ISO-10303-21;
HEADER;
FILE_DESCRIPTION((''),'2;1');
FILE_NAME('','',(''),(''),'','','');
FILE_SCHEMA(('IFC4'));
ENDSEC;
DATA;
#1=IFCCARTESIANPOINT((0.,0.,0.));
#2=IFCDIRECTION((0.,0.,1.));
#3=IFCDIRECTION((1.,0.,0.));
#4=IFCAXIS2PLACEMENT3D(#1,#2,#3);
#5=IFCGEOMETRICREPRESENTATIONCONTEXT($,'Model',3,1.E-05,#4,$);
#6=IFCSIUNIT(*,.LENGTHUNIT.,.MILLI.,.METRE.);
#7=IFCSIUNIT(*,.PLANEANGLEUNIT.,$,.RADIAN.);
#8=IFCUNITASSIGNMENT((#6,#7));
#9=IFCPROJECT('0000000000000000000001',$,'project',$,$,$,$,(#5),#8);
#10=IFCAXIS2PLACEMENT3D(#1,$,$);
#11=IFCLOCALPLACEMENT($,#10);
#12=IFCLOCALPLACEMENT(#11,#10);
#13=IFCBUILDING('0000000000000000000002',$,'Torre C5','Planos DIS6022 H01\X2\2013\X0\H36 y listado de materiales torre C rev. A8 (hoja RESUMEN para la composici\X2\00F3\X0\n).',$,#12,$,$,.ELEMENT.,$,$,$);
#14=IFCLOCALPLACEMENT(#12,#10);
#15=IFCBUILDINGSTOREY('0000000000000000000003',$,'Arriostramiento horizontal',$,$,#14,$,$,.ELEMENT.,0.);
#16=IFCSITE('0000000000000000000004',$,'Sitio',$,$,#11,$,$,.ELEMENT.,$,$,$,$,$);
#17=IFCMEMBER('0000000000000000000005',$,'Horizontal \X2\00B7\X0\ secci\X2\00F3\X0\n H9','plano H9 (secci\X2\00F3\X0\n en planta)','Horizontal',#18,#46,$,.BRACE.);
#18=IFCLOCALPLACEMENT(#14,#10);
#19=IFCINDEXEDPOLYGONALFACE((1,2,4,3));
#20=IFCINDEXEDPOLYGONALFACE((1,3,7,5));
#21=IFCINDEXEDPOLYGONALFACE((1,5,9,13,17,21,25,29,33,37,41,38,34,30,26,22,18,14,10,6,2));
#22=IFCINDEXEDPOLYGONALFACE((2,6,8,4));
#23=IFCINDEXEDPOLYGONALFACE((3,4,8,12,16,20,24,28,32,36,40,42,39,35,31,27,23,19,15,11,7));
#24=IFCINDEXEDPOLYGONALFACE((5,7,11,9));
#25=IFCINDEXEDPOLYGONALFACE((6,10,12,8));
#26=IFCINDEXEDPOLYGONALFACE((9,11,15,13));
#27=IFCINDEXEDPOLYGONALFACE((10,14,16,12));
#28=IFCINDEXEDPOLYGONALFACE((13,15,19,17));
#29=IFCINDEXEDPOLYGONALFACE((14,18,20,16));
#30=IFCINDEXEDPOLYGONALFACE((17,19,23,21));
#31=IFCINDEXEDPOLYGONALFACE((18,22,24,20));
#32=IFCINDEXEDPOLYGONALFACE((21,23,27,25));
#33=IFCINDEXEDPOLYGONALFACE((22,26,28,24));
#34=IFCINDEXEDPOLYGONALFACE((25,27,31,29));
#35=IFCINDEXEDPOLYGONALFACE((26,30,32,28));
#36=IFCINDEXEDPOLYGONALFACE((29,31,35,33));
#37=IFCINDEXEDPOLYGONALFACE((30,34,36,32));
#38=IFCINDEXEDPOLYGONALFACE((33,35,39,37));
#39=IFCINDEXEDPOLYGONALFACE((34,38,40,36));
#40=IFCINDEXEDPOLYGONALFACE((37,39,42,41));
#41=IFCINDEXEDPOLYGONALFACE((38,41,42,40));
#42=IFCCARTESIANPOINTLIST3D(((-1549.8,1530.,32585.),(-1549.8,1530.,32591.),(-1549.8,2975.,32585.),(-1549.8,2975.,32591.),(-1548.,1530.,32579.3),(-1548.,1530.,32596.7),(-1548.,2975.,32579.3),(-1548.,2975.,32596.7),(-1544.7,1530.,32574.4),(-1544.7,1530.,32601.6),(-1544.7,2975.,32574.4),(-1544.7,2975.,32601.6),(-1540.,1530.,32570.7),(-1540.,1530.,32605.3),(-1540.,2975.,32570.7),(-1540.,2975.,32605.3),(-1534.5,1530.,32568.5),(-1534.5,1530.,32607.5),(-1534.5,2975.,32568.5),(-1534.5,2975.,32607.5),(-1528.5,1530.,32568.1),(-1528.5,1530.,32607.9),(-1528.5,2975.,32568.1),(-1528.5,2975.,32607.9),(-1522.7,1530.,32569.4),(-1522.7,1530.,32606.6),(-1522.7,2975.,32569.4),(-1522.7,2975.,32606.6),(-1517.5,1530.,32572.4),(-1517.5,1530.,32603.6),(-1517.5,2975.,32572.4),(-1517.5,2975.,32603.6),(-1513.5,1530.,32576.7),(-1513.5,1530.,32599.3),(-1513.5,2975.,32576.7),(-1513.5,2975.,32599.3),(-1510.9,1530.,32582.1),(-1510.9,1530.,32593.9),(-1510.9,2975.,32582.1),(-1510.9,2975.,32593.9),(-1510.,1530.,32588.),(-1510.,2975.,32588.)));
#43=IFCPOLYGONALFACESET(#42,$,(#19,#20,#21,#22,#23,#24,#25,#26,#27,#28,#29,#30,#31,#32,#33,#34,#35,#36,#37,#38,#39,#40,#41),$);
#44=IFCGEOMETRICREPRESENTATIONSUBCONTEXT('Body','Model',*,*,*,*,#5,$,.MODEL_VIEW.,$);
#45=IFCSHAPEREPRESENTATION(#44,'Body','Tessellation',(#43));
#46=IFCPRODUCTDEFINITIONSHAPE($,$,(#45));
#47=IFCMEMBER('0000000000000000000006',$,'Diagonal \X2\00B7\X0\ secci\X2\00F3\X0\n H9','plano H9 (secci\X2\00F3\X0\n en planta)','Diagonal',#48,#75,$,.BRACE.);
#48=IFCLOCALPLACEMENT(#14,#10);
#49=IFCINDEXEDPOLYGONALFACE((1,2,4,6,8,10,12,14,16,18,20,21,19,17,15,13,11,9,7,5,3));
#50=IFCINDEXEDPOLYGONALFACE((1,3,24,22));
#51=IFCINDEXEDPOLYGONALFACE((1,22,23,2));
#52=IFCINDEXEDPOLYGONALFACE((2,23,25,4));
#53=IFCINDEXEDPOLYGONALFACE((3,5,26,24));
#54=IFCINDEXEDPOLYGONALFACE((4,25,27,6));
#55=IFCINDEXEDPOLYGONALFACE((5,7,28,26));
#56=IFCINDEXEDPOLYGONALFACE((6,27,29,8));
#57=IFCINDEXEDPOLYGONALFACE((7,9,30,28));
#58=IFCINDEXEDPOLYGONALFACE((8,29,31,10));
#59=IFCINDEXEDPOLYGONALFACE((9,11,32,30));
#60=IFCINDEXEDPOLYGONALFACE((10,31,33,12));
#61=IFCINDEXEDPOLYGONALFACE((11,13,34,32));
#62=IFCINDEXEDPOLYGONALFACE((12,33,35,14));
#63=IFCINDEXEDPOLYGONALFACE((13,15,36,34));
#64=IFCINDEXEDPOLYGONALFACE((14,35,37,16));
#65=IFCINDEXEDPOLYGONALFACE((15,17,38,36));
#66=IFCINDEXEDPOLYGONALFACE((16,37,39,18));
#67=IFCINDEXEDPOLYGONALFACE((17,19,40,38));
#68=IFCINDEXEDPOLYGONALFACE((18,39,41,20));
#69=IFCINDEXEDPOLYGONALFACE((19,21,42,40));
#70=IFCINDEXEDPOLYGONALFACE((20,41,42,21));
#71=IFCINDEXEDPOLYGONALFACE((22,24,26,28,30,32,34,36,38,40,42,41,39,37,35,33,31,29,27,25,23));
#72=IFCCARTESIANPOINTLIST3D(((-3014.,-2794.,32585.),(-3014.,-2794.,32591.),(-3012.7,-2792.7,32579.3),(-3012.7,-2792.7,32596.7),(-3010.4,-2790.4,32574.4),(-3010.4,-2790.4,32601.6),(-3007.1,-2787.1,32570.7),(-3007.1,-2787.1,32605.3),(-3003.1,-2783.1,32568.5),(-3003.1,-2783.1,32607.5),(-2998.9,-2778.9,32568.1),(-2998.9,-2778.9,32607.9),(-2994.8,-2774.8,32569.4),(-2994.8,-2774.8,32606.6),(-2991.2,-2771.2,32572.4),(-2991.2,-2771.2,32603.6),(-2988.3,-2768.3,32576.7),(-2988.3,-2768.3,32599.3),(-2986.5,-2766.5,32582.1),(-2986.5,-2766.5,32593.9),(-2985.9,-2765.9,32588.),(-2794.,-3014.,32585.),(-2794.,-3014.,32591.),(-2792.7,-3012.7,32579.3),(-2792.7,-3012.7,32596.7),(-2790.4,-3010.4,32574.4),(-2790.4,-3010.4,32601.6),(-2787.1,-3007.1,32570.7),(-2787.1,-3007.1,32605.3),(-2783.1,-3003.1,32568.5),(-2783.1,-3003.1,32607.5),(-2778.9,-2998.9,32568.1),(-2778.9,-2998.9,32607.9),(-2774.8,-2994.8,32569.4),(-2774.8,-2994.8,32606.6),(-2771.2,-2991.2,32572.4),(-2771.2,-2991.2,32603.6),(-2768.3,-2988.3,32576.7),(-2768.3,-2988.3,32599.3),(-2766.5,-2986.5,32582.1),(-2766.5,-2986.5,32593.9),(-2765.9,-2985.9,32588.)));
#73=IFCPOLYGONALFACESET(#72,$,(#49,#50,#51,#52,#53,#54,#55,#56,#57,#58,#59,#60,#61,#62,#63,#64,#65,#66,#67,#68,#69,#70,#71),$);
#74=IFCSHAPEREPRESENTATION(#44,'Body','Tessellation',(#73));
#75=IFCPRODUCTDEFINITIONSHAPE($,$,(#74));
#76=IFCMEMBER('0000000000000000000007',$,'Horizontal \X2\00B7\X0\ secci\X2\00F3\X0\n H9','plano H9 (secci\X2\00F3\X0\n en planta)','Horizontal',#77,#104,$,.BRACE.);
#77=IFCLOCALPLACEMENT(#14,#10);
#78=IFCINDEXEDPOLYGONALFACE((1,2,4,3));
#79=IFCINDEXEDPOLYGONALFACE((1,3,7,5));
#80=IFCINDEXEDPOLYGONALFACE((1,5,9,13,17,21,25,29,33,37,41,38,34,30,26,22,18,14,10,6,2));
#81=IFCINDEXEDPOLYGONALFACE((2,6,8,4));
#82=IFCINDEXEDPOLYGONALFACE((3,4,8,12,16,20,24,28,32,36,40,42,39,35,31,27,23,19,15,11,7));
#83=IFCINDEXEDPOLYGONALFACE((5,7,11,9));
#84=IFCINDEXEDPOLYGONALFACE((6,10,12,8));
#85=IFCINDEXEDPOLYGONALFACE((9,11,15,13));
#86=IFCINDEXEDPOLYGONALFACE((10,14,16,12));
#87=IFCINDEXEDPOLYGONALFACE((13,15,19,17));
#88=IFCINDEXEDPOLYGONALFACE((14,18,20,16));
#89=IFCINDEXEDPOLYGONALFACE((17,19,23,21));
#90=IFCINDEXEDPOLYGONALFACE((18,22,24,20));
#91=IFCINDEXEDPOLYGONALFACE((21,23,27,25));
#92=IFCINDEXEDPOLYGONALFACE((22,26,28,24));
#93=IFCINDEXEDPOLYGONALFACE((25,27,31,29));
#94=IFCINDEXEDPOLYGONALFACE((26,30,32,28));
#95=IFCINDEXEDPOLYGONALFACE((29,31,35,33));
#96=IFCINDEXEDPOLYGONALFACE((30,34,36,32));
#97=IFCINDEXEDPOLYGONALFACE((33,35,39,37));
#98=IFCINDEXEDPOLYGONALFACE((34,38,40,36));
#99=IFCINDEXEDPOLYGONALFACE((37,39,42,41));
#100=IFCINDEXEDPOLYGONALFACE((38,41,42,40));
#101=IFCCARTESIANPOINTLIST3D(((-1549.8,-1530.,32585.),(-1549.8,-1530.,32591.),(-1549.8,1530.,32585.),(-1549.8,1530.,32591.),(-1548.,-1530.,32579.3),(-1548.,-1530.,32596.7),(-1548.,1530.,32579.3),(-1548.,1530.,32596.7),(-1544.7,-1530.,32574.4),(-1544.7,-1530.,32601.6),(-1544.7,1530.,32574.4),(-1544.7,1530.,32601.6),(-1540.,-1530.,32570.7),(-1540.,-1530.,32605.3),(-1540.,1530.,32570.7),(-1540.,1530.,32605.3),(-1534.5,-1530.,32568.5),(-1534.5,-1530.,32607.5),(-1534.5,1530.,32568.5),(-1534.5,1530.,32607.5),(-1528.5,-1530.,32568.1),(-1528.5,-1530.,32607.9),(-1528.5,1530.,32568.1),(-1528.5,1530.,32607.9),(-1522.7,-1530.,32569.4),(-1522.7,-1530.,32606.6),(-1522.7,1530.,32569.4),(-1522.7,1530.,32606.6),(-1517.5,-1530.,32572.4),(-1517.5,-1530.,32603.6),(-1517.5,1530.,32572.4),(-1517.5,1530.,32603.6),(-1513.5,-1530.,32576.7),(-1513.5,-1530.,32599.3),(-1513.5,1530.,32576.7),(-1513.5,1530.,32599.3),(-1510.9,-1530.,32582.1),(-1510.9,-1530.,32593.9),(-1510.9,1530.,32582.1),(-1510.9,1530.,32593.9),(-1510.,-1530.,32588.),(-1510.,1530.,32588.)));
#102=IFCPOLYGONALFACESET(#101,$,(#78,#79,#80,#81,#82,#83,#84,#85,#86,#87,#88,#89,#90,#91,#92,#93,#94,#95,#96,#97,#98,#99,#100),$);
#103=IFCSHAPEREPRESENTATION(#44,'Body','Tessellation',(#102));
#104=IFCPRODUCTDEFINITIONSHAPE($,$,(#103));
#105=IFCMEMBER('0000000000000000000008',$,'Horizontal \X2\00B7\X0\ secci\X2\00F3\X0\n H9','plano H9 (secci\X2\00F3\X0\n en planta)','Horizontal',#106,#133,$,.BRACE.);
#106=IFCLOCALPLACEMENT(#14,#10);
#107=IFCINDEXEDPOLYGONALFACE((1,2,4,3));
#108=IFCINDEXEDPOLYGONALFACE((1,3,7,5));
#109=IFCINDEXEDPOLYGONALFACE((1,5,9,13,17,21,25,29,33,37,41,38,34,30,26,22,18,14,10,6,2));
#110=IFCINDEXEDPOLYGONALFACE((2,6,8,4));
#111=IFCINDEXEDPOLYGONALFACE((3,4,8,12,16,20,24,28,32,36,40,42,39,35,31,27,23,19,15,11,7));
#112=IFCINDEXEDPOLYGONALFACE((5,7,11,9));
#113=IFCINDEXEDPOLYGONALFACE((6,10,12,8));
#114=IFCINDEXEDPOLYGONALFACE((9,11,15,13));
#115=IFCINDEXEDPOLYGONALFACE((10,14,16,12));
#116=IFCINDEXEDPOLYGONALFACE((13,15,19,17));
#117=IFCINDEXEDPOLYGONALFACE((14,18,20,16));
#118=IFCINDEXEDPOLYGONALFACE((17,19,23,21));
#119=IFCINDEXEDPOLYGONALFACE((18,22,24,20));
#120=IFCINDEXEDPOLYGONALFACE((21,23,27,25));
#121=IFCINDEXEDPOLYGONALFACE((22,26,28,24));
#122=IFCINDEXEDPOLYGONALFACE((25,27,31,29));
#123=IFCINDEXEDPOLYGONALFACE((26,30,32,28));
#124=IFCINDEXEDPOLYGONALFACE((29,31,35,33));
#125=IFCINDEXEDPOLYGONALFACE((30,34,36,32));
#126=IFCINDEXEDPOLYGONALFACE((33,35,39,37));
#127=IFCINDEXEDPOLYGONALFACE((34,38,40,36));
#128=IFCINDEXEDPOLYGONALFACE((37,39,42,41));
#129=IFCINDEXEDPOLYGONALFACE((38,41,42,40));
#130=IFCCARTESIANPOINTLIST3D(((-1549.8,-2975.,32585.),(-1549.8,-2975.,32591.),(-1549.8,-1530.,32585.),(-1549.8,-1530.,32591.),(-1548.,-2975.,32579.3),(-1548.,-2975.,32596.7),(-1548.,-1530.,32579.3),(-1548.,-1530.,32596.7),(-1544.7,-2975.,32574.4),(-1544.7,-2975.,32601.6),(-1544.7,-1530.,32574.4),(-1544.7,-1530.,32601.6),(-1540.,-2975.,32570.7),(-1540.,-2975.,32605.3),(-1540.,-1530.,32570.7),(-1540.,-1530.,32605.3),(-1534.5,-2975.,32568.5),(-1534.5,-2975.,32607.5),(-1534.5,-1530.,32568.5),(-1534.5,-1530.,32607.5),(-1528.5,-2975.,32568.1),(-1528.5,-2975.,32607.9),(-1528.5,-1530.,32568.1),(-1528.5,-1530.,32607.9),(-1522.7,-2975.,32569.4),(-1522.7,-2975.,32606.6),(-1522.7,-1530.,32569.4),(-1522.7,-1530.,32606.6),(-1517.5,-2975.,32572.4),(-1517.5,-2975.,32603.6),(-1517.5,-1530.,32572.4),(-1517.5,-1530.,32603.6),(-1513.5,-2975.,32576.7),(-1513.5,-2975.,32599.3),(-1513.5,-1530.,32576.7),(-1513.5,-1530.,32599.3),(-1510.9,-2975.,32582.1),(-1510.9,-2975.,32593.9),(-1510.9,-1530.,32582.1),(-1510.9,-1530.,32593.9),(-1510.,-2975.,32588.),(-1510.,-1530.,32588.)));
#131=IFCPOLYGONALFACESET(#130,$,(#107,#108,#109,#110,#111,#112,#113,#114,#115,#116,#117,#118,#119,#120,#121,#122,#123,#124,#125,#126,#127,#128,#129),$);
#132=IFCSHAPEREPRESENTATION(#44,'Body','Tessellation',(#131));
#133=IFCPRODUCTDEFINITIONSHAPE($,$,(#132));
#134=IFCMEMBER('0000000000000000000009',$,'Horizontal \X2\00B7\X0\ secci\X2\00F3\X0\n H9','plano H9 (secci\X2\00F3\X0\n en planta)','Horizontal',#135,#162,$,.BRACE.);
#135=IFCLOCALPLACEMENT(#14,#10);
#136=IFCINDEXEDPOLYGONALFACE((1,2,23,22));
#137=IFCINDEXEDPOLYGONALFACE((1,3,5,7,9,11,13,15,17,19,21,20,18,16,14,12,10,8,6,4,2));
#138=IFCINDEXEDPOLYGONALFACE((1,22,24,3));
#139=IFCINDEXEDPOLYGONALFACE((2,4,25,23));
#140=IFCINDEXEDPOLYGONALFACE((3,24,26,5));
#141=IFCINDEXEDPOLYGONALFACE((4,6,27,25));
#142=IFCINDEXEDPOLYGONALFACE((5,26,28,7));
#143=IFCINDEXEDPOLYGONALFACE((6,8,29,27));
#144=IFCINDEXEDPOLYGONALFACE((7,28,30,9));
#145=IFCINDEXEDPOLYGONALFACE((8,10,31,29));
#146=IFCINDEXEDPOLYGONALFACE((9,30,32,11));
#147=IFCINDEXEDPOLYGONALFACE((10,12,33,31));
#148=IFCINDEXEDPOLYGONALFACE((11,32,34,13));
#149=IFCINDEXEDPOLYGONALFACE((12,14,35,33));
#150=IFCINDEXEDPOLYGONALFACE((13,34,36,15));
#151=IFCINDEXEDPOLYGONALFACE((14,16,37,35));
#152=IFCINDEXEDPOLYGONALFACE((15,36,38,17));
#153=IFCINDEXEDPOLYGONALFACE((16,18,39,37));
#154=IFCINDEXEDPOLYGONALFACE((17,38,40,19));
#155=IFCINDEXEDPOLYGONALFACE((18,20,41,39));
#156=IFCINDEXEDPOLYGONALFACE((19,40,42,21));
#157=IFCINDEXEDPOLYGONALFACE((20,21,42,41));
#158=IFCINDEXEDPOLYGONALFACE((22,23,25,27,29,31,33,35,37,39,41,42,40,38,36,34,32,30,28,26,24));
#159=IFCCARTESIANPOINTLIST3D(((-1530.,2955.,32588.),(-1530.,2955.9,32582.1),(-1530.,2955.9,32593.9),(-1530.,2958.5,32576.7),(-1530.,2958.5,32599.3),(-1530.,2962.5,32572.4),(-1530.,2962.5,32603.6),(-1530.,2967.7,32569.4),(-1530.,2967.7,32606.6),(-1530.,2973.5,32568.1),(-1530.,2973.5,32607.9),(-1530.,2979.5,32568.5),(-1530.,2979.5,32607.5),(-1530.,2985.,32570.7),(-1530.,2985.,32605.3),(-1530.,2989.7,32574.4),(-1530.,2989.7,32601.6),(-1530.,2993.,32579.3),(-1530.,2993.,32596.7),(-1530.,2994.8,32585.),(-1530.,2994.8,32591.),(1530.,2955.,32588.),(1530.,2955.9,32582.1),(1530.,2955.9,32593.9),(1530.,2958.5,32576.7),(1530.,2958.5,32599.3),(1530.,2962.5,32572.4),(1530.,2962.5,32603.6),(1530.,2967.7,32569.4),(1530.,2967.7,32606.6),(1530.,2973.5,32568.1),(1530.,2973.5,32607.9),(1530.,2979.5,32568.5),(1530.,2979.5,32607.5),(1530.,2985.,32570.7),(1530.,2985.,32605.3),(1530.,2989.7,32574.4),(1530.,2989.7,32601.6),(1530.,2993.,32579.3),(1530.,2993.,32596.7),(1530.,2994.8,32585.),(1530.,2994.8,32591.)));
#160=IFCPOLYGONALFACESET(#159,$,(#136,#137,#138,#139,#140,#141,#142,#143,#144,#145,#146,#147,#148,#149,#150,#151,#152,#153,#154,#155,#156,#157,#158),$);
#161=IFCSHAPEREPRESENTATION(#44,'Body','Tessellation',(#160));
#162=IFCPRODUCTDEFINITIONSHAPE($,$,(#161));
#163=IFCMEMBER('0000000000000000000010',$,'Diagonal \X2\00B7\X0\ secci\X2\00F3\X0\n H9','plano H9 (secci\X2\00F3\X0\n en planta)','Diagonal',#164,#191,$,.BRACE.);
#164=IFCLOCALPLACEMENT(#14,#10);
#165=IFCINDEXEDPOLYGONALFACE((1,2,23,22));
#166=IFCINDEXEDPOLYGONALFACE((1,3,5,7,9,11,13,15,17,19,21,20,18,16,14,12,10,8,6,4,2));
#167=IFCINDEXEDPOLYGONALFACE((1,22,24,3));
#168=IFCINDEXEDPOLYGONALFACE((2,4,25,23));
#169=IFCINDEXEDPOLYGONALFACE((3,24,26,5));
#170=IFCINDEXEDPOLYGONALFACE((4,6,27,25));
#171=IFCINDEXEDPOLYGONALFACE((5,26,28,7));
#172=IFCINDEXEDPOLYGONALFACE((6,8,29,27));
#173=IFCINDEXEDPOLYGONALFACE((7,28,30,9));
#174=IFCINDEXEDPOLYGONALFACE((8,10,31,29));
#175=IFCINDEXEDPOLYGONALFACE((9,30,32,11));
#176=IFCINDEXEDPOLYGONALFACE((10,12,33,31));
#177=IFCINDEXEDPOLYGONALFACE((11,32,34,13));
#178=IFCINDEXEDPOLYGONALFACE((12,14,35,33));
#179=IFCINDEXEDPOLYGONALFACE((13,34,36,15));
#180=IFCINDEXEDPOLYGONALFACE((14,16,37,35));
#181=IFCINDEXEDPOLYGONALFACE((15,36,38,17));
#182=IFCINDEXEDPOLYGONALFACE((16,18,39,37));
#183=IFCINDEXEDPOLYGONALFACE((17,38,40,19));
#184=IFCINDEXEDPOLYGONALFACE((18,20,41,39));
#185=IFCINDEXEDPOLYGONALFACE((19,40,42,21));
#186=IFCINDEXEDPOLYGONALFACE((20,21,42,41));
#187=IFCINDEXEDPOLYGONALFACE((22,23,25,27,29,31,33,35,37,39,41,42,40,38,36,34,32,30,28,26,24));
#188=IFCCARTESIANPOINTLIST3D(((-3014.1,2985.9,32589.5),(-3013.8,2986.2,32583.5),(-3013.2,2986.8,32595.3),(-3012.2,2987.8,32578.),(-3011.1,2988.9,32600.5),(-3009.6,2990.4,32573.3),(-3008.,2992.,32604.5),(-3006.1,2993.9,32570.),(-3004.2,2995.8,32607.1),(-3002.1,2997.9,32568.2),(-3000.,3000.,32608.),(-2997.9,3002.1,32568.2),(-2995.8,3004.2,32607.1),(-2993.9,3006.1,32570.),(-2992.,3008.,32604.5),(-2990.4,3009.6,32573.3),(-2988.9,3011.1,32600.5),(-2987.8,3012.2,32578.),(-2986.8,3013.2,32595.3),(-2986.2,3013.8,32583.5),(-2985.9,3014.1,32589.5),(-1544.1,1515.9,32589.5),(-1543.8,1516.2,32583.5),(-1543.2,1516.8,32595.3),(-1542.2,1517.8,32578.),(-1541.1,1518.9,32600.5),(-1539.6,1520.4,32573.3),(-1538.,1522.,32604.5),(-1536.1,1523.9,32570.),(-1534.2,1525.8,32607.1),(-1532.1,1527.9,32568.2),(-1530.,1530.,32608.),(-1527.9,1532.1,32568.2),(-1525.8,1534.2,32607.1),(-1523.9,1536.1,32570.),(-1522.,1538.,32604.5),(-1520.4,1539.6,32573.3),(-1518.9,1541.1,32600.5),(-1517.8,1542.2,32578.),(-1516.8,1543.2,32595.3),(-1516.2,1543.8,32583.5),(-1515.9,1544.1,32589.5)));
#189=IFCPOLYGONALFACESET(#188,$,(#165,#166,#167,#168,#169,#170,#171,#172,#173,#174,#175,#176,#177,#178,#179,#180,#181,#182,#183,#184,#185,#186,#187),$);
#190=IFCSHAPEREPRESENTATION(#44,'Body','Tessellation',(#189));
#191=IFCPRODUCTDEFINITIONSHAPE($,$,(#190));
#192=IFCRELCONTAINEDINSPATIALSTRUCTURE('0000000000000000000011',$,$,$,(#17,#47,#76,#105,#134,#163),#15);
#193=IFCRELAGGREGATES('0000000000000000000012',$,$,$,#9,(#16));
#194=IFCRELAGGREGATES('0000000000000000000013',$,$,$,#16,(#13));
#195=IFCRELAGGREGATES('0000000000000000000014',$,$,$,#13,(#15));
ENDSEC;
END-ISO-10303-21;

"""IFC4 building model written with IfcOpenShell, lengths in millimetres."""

from ifc_helpers import new_model, si_unit, frame, origin, origin_with_axes, place, context, subcontext, project, spatial, circle, extrude, element, save


model = new_model("IFC4")

# Units and contexts
model_context = context("Model", 3, precision=1e-05, world=origin_with_axes())
body_context = subcontext(model_context, "Body", "Model", "MODEL_VIEW")
ifc_project = project(units=[si_unit("LENGTHUNIT", "METRE", prefix="MILLI"), si_unit("PLANEANGLEUNIT", "RADIAN")], contexts=[model_context])

# Site, building, storey
site_placement = place(None, origin())
site = spatial("IfcSite", under=ifc_project, at=site_placement, Name="Sitio", CompositionType="ELEMENT")
building_placement = place(site_placement, origin())
building = spatial("IfcBuilding", under=site, at=building_placement, Name="Torre C5", Description="Planos DIS6022 H01–H36 y listado de materiales torre C rev. A8 (hoja RESUMEN para la composición).", CompositionType="ELEMENT")
storey_placement = place(building_placement, origin())
storey = spatial("IfcBuildingStorey", under=building, at=storey_placement, Name="Arriostramiento horizontal", CompositionType="ELEMENT", Elevation=0.0)

# Members
member_1_placement = place(storey_placement, frame((-1530.0, 1530.0, 32588.0), z_axis=(0.0, 1.0, 0.0), x_axis=(1.0, 0.0, 0.0)))
element("IfcMember", 1, at=member_1_placement, inside=storey, Name="Horizontal · sección H9", Description="plano H9 (sección en planta)", ObjectType="Horizontal", PredefinedType="BRACE", context=body_context, shape_type="SweptSolid", body=[
    extrude(circle(Radius=20.0), None, (0.0, 0.0, 1.0), 1445.0),
])
member_2_placement = place(storey_placement, frame((-3000.0, -2780.0, 32588.0), z_axis=(0.707107, -0.707107, 0.0), x_axis=(0.707107, 0.707107, 0.0)))
element("IfcMember", 2, at=member_2_placement, inside=storey, Name="Diagonal · sección H9", Description="plano H9 (sección en planta)", ObjectType="Diagonal", PredefinedType="BRACE", context=body_context, shape_type="SweptSolid", body=[
    extrude(circle(Radius=20.0), None, (0.0, 0.0, 1.0), 311.1),
])
member_3_placement = place(storey_placement, frame((-1530.0, 1530.0, 32588.0), z_axis=(0.0, -1.0, 0.0), x_axis=(1.0, 0.0, 0.0)))
element("IfcMember", 3, at=member_3_placement, inside=storey, Name="Horizontal · sección H9", Description="plano H9 (sección en planta)", ObjectType="Horizontal", PredefinedType="BRACE", context=body_context, shape_type="SweptSolid", body=[
    extrude(circle(Radius=20.0), None, (0.0, 0.0, 1.0), 3060.0),
])
member_4_placement = place(storey_placement, frame((-1530.0, -1530.0, 32588.0), z_axis=(0.0, -1.0, 0.0), x_axis=(1.0, 0.0, 0.0)))
element("IfcMember", 4, at=member_4_placement, inside=storey, Name="Horizontal · sección H9", Description="plano H9 (sección en planta)", ObjectType="Horizontal", PredefinedType="BRACE", context=body_context, shape_type="SweptSolid", body=[
    extrude(circle(Radius=20.0), None, (0.0, 0.0, 1.0), 1445.0),
])
member_5_placement = place(storey_placement, frame((-1530.0, 2975.0, 32588.0), z_axis=(1.0, 0.0, 0.0), x_axis=(0.0, -1.0, 0.0)))
element("IfcMember", 5, at=member_5_placement, inside=storey, Name="Horizontal · sección H9", Description="plano H9 (sección en planta)", ObjectType="Horizontal", PredefinedType="BRACE", context=body_context, shape_type="SweptSolid", body=[
    extrude(circle(Radius=20.0), None, (0.0, 0.0, 1.0), 3060.0),
])
for number, where, z_axis, x_axis, name in (
    (6, (-3000.0, 3000.0, 32588.0), (0.707107, -0.707107, 0.0), (0.0, 0.0, 1.0), "Diagonal · sección H9"),
):
    element("IfcMember", number, at=place(storey_placement, frame(where, z_axis=z_axis, x_axis=x_axis)), inside=storey, Name=name, Description="plano H9 (sección en planta)", ObjectType="Diagonal", PredefinedType="BRACE", context=body_context, shape_type="SweptSolid", body=[
        extrude(circle(Radius=20.0), None, (0.0, 0.0, 1.0), 2078.9),
    ])

save(model, "model.ifc")
